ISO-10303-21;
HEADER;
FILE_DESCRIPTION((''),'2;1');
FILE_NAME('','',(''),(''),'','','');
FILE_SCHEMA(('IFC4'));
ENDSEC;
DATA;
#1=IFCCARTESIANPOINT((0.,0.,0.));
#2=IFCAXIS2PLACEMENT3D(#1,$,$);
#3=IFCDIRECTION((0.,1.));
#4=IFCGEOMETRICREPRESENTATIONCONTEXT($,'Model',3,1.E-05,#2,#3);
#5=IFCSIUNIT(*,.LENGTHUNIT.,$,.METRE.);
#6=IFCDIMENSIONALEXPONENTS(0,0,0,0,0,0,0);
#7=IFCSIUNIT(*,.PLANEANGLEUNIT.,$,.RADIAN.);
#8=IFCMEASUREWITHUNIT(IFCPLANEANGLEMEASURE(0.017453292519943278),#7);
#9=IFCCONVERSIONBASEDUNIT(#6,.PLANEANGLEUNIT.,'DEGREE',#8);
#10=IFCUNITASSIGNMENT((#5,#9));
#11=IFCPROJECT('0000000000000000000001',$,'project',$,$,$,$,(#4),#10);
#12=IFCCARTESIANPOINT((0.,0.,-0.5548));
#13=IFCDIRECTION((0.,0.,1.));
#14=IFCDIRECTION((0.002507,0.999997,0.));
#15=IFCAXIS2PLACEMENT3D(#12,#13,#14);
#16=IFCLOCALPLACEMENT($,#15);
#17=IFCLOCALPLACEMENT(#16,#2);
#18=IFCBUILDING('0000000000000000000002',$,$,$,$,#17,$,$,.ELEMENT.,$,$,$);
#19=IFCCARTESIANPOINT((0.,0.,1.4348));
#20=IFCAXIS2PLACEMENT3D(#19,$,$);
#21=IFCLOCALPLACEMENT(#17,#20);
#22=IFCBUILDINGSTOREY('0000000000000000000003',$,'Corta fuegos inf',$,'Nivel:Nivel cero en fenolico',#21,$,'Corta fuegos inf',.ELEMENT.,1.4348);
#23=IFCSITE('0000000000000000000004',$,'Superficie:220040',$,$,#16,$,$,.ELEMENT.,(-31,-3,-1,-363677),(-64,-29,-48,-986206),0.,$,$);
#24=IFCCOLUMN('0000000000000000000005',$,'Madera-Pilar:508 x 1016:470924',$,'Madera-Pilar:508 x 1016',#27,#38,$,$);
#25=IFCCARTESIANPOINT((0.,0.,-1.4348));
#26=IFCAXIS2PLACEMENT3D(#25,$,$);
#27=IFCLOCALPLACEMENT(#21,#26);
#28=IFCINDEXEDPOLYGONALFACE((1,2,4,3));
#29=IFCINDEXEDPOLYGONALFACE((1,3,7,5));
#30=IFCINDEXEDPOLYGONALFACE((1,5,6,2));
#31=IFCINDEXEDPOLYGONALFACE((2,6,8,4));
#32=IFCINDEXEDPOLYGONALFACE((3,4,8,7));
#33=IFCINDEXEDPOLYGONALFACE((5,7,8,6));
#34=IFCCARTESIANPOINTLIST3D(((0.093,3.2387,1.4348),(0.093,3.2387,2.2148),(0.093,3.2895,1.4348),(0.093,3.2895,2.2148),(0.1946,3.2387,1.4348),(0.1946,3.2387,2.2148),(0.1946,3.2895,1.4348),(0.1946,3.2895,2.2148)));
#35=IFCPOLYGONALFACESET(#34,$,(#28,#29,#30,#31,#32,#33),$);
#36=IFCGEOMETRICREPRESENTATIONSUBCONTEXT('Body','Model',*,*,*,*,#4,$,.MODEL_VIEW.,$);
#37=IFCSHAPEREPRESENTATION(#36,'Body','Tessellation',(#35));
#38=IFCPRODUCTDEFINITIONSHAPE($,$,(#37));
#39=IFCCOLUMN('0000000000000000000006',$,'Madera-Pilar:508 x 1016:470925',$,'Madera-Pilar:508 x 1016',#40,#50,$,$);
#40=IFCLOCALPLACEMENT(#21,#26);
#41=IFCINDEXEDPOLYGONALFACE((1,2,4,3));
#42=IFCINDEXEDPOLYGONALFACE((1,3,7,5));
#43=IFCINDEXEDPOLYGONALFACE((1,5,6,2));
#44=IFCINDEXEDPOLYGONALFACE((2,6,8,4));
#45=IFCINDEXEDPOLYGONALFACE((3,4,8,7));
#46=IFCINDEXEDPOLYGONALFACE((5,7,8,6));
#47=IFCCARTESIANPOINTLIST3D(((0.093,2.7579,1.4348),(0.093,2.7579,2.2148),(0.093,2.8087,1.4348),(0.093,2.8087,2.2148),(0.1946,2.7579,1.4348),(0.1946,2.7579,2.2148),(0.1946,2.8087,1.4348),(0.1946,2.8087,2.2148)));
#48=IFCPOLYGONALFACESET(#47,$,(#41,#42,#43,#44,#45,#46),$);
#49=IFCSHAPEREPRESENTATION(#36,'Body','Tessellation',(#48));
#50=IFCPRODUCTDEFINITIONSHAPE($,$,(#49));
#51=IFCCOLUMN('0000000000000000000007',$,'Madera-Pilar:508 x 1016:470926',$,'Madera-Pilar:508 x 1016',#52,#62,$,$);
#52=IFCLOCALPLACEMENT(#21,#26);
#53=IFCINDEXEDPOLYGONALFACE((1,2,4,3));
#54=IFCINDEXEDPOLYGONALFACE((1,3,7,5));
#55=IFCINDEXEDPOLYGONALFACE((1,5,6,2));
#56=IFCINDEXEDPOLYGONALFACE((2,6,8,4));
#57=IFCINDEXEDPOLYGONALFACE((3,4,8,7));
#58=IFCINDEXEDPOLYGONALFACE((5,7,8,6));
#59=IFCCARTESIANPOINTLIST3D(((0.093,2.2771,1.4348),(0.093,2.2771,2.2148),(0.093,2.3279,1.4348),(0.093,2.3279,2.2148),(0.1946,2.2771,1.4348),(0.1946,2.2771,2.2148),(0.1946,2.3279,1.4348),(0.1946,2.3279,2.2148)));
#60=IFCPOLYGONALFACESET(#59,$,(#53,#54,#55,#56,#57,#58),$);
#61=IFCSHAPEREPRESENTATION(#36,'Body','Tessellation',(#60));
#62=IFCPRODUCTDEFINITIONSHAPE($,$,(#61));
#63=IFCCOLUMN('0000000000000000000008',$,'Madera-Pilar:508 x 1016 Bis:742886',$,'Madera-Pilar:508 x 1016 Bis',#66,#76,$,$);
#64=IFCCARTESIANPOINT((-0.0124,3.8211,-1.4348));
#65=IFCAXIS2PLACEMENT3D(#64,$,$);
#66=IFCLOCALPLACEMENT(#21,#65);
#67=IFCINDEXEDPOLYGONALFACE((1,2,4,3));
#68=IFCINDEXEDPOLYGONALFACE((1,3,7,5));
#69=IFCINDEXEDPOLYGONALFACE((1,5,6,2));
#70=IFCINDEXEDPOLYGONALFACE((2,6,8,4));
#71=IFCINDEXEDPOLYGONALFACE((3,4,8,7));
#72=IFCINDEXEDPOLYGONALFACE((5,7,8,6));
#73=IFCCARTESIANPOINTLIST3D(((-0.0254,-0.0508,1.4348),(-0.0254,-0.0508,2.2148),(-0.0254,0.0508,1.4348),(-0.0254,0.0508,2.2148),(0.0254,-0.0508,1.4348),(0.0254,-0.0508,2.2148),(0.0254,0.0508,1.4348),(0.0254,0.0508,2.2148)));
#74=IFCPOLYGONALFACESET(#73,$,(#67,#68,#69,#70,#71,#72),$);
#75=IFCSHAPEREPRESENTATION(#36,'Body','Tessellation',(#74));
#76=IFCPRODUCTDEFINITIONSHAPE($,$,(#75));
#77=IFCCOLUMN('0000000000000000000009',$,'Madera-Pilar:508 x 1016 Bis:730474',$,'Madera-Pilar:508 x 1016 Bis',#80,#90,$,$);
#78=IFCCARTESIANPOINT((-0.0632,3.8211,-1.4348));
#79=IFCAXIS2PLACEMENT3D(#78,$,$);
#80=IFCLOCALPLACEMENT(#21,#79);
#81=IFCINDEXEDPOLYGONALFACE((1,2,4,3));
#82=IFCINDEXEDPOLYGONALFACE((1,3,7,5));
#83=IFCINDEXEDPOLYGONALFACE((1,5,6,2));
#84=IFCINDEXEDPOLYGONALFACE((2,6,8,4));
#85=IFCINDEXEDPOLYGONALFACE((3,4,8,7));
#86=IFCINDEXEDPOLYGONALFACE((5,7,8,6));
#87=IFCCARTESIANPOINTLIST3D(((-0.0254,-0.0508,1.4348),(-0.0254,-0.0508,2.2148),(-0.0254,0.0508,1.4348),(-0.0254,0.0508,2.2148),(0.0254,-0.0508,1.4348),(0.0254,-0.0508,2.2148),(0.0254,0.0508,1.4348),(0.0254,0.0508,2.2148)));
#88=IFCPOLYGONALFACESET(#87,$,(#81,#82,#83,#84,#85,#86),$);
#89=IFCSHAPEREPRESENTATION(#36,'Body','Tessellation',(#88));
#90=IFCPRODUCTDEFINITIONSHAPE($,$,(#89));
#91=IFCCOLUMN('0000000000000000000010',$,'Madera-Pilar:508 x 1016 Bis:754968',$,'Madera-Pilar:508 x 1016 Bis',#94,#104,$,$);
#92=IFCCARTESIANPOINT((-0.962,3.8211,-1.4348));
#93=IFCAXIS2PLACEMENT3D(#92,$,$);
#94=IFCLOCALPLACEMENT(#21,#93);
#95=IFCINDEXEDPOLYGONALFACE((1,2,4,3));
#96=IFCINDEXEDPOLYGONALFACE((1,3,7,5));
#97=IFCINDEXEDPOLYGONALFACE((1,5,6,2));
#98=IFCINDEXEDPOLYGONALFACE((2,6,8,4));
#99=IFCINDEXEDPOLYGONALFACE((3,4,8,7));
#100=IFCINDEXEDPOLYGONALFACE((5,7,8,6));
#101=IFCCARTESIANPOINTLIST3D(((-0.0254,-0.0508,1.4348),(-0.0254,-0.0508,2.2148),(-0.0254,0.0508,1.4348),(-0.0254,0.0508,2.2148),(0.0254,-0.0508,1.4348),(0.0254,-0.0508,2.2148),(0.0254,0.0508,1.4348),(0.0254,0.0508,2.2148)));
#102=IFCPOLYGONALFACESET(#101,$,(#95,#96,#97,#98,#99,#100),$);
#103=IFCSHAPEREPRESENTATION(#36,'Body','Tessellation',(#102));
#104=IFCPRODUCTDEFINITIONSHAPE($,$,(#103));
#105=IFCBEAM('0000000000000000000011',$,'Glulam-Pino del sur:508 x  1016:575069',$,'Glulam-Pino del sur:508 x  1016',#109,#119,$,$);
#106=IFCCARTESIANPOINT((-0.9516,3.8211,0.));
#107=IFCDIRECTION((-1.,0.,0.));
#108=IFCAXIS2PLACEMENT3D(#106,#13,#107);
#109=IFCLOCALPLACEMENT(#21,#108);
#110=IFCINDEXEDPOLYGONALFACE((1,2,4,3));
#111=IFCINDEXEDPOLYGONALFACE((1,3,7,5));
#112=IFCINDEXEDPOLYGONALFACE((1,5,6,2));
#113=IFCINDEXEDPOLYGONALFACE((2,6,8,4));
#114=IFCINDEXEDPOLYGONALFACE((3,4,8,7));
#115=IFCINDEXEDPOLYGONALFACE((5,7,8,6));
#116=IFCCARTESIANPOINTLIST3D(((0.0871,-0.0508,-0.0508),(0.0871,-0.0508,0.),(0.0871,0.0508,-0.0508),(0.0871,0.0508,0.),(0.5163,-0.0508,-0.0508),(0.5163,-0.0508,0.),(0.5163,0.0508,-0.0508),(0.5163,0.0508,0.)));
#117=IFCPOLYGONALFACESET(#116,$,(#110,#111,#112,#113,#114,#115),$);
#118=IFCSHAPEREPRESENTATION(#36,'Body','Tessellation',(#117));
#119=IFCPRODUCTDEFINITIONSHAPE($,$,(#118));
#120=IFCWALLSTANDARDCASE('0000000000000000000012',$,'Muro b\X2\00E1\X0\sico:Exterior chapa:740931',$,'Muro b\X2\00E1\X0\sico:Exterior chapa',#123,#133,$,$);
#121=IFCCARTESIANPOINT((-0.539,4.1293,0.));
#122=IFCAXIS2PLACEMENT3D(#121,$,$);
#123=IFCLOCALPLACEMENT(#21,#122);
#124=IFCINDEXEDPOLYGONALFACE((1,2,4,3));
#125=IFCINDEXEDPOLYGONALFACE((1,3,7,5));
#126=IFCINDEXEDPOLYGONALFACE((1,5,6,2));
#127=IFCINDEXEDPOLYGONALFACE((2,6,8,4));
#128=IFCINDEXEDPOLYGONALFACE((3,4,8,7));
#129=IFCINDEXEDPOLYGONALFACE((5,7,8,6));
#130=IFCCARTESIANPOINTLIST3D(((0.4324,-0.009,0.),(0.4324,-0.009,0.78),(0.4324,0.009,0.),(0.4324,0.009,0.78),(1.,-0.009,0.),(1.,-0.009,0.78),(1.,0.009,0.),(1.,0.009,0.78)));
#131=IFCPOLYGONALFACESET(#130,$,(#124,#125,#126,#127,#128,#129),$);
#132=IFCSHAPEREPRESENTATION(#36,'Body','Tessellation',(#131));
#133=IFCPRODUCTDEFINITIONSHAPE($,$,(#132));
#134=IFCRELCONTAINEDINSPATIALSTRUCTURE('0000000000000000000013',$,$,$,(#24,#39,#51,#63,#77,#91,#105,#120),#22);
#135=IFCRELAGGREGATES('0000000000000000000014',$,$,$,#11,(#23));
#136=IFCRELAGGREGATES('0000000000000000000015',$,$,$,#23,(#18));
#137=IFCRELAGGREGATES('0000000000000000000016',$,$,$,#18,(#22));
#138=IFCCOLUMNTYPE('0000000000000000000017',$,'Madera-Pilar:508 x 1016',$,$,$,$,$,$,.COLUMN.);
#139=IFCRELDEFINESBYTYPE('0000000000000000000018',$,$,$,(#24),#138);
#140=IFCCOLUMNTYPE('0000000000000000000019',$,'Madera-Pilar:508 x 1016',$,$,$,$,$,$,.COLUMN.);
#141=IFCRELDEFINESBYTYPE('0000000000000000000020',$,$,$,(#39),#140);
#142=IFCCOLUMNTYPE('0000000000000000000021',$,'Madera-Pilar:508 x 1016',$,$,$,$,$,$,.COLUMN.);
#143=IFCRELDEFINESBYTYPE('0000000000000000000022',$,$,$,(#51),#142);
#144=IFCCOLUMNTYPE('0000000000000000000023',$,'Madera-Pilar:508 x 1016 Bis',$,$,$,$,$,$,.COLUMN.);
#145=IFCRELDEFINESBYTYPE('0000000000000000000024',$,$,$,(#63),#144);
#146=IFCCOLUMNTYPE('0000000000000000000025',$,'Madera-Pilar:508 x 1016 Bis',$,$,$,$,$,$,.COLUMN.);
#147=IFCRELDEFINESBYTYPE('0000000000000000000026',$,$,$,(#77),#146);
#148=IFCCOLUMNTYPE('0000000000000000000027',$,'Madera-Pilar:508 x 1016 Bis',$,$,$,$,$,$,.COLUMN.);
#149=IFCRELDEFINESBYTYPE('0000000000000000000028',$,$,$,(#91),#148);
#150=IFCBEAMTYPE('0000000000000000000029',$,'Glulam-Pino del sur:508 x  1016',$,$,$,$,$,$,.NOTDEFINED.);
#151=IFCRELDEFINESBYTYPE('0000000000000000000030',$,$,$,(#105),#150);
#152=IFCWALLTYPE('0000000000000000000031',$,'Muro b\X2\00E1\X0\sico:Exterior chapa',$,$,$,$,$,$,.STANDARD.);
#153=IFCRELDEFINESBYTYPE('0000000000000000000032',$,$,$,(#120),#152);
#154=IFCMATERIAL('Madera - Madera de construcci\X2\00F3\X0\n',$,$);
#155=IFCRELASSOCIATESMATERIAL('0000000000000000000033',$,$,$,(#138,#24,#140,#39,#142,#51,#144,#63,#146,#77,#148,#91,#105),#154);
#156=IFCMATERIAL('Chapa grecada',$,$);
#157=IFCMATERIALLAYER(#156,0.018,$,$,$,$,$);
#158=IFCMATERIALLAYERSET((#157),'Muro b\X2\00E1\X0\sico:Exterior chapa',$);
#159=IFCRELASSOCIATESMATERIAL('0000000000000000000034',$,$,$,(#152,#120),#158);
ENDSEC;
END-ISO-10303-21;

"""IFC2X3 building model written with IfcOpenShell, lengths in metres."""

from ifc_helpers import new_model, entity, si_unit, converted_unit, direction, frame, frame_2d, origin, origin_2d_with_axis, place, context, subcontext, project, spatial, rectangle, extrude, source, transform, mapped, material, layer, layer_set, layer_usage, type_object, type_shapes, element, save


model = new_model("IFC2X3")

# Units and contexts
model_context = context("Model", 3, precision=1e-05, world=origin(), true_north=direction((0.0, 1.0)))
body_context = subcontext(model_context, "Body", "Model", "MODEL_VIEW")
ifc_project = project(units=[si_unit("LENGTHUNIT", "METRE"), converted_unit("PLANEANGLEUNIT", "DEGREE", entity("IfcPlaneAngleMeasure", 0.017453292519943278), si_unit("PLANEANGLEUNIT", "RADIAN"), dimensions=[0, 0, 0, 0, 0, 0, 0])], contexts=[model_context])

# Site, building, storey
site_placement = place(None, frame((0.0, 0.0, -0.5548), z_axis=(0.0, 0.0, 1.0), x_axis=(0.002507, 0.999997, 0.0)))
site = spatial("IfcSite", under=ifc_project, at=site_placement, Name="Superficie:220040", CompositionType="ELEMENT", RefLatitude=(-31, -3, -1, -363677), RefLongitude=(-64, -29, -48, -986206), RefElevation=0.0)
building_placement = place(site_placement, origin())
building = spatial("IfcBuilding", under=site, at=building_placement, CompositionType="ELEMENT")
storey_placement = place(building_placement, frame((0.0, 0.0, 1.4348)))
storey = spatial("IfcBuildingStorey", under=building, at=storey_placement, Name="Corta fuegos inf", ObjectType="Nivel:Nivel cero en fenolico", LongName="Corta fuegos inf", CompositionType="ELEMENT", Elevation=1.4348)

# Columns
ifc_material_1 = material(Name="Madera - Madera de construcción")
column_type_1 = type_object("IfcColumnType", Name="Madera-Pilar:508 x 1016", PredefinedType="COLUMN", material=ifc_material_1)
shared_shape_1 = source(origin(), body_context, "Body", "SweptSolid", [
    extrude(rectangle(XDim=0.1016, YDim=0.0508, at=frame_2d((0.0, 0.0), x_axis=(1.0, 0.0))), frame((0.1438, 3.2641, 1.4348), z_axis=(0.0, 0.0, 1.0), x_axis=(-1.0, 0.0, 0.0)), (0.0, 0.0, 1.0), 0.78),
])
type_shapes(column_type_1, [shared_shape_1])
column_1_placement = place(storey_placement, frame((0.0, 0.0, -1.4348)))
element("IfcColumn", 1, at=column_1_placement, inside=storey, type_object=column_type_1, material=ifc_material_1, Name="Madera-Pilar:508 x 1016:470924", ObjectType="Madera-Pilar:508 x 1016", context=body_context, shape_type="MappedRepresentation", body=[
    mapped(shared_shape_1, transform((0.0, 0.0, 0.0), scale=1.0)),
])
column_type_2 = type_object("IfcColumnType", Name="Madera-Pilar:508 x 1016", PredefinedType="COLUMN", material=ifc_material_1)
shared_shape_2 = source(origin(), body_context, "Body", "SweptSolid", [
    extrude(rectangle(XDim=0.1016, YDim=0.0508, at=frame_2d((0.0, 0.0), x_axis=(1.0, 0.0))), frame((0.1438, 2.7833, 1.4348), z_axis=(0.0, 0.0, 1.0), x_axis=(-1.0, 0.0, 0.0)), (0.0, 0.0, 1.0), 0.78),
])
type_shapes(column_type_2, [shared_shape_2])
column_2_placement = place(storey_placement, frame((0.0, 0.0, -1.4348)))
element("IfcColumn", 2, at=column_2_placement, inside=storey, type_object=column_type_2, material=ifc_material_1, Name="Madera-Pilar:508 x 1016:470925", ObjectType="Madera-Pilar:508 x 1016", context=body_context, shape_type="MappedRepresentation", body=[
    mapped(shared_shape_2, transform((0.0, 0.0, 0.0), scale=1.0)),
])
column_type_3 = type_object("IfcColumnType", Name="Madera-Pilar:508 x 1016", PredefinedType="COLUMN", material=ifc_material_1)
shared_shape_3 = source(origin(), body_context, "Body", "SweptSolid", [
    extrude(rectangle(XDim=0.1016, YDim=0.0508, at=frame_2d((0.0, 0.0), x_axis=(1.0, 0.0))), frame((0.1438, 2.3025, 1.4348), z_axis=(0.0, 0.0, 1.0), x_axis=(-1.0, 0.0, 0.0)), (0.0, 0.0, 1.0), 0.78),
])
type_shapes(column_type_3, [shared_shape_3])
column_3_placement = place(storey_placement, frame((0.0, 0.0, -1.4348)))
element("IfcColumn", 3, at=column_3_placement, inside=storey, type_object=column_type_3, material=ifc_material_1, Name="Madera-Pilar:508 x 1016:470926", ObjectType="Madera-Pilar:508 x 1016", context=body_context, shape_type="MappedRepresentation", body=[
    mapped(shared_shape_3, transform((0.0, 0.0, 0.0), scale=1.0)),
])
column_type_4 = type_object("IfcColumnType", Name="Madera-Pilar:508 x 1016 Bis", PredefinedType="COLUMN", material=ifc_material_1)
shared_shape_4 = source(origin(), body_context, "Body", "SweptSolid", [
    extrude(rectangle(XDim=0.0508, YDim=0.1016, at=origin_2d_with_axis()), frame((0.0, 0.0, 1.4348), z_axis=(0.0, 0.0, 1.0), x_axis=(-1.0, 0.0, 0.0)), (0.0, 0.0, 1.0), 0.78),
])
type_shapes(column_type_4, [shared_shape_4])
column_4_placement = place(storey_placement, frame((-0.0124, 3.8211, -1.4348)))
element("IfcColumn", 4, at=column_4_placement, inside=storey, type_object=column_type_4, material=ifc_material_1, Name="Madera-Pilar:508 x 1016 Bis:742886", ObjectType="Madera-Pilar:508 x 1016 Bis", context=body_context, shape_type="MappedRepresentation", body=[
    mapped(shared_shape_4, transform((0.0, 0.0, 0.0), scale=1.0)),
])
column_type_5 = type_object("IfcColumnType", Name="Madera-Pilar:508 x 1016 Bis", PredefinedType="COLUMN", material=ifc_material_1)
shared_shape_5 = source(origin(), body_context, "Body", "SweptSolid", [
    extrude(rectangle(XDim=0.0508, YDim=0.1016, at=frame_2d((0.0, 0.0), x_axis=(1.0, 0.0))), frame((0.0, 0.0, 1.4348), z_axis=(0.0, 0.0, 1.0), x_axis=(-1.0, 0.0, 0.0)), (0.0, 0.0, 1.0), 0.78),
])
type_shapes(column_type_5, [shared_shape_5])
column_5_placement = place(storey_placement, frame((-0.0632, 3.8211, -1.4348)))
element("IfcColumn", 5, at=column_5_placement, inside=storey, type_object=column_type_5, material=ifc_material_1, Name="Madera-Pilar:508 x 1016 Bis:730474", ObjectType="Madera-Pilar:508 x 1016 Bis", context=body_context, shape_type="MappedRepresentation", body=[
    mapped(shared_shape_5, transform((0.0, 0.0, 0.0), scale=1.0)),
])
column_type_6 = type_object("IfcColumnType", Name="Madera-Pilar:508 x 1016 Bis", PredefinedType="COLUMN", material=ifc_material_1)
shared_shape_6 = source(origin(), body_context, "Body", "SweptSolid", [
    extrude(rectangle(XDim=0.0508, YDim=0.1016, at=frame_2d((0.0, 0.0), x_axis=(1.0, 0.0))), frame((0.0, 0.0, 1.4348), z_axis=(0.0, 0.0, 1.0), x_axis=(-1.0, 0.0, 0.0)), (0.0, 0.0, 1.0), 0.78),
])
type_shapes(column_type_6, [shared_shape_6])
column_6_placement = place(storey_placement, frame((-0.962, 3.8211, -1.4348)))
element("IfcColumn", 6, at=column_6_placement, inside=storey, type_object=column_type_6, material=ifc_material_1, Name="Madera-Pilar:508 x 1016 Bis:754968", ObjectType="Madera-Pilar:508 x 1016 Bis", context=body_context, shape_type="MappedRepresentation", body=[
    mapped(shared_shape_6, transform((0.0, 0.0, 0.0), scale=1.0)),
])

# Beam
beam_type_1 = type_object("IfcBeamType", Name="Glulam-Pino del sur:508 x  1016", PredefinedType="NOTDEFINED")
beam_1_placement = place(storey_placement, frame((-0.9516, 3.8211, 0.0), z_axis=(0.0, 0.0, 1.0), x_axis=(-1.0, 0.0, 0.0)))
element("IfcBeam", 7, at=beam_1_placement, inside=storey, type_object=beam_type_1, material=ifc_material_1, Name="Glulam-Pino del sur:508 x  1016:575069", ObjectType="Glulam-Pino del sur:508 x  1016", context=body_context, shape_type="SweptSolid", body=[
    extrude(rectangle(XDim=0.0508, YDim=0.1016, at=frame_2d((0.0, 0.0), x_axis=(1.0, 0.0))), frame((0.0871, 0.0, -0.0254), z_axis=(1.0, 0.0, 0.0), x_axis=(0.0, 0.0, -1.0)), (0.0, 0.0, 1.0), 0.4292),
])

# Wall
ifc_material_2 = material(Name="Chapa grecada")
ifc_layer_1 = layer(ifc_material_2, 0.018)
ifc_layer_set_1 = layer_set([ifc_layer_1], Name="Muro básico:Exterior chapa")
ifc_layer_usage_1 = layer_usage(ifc_layer_set_1, "AXIS2", "POSITIVE", -0.009)
wall_type_1 = type_object("IfcWallType", Name="Muro básico:Exterior chapa", PredefinedType="STANDARD", material=ifc_layer_set_1)
wall_1_placement = place(storey_placement, frame((-0.539, 4.1293, 0.0)))
element("IfcWallStandardCase", 8, at=wall_1_placement, inside=storey, type_object=wall_type_1, material=ifc_layer_usage_1, Name="Muro básico:Exterior chapa:740931", ObjectType="Muro básico:Exterior chapa", context=body_context, shape_type="SweptSolid", body=[
    extrude(rectangle(XDim=0.018, YDim=0.5676, at=frame_2d((0.0, 0.0), x_axis=(1.0, 0.0))), frame((0.7162, 0.0, 0.0), z_axis=(0.0, 0.0, 1.0), x_axis=(0.0, 1.0, 0.0)), (0.0, 0.0, 1.0), 0.78),
])

save(model, "model.ifc")
